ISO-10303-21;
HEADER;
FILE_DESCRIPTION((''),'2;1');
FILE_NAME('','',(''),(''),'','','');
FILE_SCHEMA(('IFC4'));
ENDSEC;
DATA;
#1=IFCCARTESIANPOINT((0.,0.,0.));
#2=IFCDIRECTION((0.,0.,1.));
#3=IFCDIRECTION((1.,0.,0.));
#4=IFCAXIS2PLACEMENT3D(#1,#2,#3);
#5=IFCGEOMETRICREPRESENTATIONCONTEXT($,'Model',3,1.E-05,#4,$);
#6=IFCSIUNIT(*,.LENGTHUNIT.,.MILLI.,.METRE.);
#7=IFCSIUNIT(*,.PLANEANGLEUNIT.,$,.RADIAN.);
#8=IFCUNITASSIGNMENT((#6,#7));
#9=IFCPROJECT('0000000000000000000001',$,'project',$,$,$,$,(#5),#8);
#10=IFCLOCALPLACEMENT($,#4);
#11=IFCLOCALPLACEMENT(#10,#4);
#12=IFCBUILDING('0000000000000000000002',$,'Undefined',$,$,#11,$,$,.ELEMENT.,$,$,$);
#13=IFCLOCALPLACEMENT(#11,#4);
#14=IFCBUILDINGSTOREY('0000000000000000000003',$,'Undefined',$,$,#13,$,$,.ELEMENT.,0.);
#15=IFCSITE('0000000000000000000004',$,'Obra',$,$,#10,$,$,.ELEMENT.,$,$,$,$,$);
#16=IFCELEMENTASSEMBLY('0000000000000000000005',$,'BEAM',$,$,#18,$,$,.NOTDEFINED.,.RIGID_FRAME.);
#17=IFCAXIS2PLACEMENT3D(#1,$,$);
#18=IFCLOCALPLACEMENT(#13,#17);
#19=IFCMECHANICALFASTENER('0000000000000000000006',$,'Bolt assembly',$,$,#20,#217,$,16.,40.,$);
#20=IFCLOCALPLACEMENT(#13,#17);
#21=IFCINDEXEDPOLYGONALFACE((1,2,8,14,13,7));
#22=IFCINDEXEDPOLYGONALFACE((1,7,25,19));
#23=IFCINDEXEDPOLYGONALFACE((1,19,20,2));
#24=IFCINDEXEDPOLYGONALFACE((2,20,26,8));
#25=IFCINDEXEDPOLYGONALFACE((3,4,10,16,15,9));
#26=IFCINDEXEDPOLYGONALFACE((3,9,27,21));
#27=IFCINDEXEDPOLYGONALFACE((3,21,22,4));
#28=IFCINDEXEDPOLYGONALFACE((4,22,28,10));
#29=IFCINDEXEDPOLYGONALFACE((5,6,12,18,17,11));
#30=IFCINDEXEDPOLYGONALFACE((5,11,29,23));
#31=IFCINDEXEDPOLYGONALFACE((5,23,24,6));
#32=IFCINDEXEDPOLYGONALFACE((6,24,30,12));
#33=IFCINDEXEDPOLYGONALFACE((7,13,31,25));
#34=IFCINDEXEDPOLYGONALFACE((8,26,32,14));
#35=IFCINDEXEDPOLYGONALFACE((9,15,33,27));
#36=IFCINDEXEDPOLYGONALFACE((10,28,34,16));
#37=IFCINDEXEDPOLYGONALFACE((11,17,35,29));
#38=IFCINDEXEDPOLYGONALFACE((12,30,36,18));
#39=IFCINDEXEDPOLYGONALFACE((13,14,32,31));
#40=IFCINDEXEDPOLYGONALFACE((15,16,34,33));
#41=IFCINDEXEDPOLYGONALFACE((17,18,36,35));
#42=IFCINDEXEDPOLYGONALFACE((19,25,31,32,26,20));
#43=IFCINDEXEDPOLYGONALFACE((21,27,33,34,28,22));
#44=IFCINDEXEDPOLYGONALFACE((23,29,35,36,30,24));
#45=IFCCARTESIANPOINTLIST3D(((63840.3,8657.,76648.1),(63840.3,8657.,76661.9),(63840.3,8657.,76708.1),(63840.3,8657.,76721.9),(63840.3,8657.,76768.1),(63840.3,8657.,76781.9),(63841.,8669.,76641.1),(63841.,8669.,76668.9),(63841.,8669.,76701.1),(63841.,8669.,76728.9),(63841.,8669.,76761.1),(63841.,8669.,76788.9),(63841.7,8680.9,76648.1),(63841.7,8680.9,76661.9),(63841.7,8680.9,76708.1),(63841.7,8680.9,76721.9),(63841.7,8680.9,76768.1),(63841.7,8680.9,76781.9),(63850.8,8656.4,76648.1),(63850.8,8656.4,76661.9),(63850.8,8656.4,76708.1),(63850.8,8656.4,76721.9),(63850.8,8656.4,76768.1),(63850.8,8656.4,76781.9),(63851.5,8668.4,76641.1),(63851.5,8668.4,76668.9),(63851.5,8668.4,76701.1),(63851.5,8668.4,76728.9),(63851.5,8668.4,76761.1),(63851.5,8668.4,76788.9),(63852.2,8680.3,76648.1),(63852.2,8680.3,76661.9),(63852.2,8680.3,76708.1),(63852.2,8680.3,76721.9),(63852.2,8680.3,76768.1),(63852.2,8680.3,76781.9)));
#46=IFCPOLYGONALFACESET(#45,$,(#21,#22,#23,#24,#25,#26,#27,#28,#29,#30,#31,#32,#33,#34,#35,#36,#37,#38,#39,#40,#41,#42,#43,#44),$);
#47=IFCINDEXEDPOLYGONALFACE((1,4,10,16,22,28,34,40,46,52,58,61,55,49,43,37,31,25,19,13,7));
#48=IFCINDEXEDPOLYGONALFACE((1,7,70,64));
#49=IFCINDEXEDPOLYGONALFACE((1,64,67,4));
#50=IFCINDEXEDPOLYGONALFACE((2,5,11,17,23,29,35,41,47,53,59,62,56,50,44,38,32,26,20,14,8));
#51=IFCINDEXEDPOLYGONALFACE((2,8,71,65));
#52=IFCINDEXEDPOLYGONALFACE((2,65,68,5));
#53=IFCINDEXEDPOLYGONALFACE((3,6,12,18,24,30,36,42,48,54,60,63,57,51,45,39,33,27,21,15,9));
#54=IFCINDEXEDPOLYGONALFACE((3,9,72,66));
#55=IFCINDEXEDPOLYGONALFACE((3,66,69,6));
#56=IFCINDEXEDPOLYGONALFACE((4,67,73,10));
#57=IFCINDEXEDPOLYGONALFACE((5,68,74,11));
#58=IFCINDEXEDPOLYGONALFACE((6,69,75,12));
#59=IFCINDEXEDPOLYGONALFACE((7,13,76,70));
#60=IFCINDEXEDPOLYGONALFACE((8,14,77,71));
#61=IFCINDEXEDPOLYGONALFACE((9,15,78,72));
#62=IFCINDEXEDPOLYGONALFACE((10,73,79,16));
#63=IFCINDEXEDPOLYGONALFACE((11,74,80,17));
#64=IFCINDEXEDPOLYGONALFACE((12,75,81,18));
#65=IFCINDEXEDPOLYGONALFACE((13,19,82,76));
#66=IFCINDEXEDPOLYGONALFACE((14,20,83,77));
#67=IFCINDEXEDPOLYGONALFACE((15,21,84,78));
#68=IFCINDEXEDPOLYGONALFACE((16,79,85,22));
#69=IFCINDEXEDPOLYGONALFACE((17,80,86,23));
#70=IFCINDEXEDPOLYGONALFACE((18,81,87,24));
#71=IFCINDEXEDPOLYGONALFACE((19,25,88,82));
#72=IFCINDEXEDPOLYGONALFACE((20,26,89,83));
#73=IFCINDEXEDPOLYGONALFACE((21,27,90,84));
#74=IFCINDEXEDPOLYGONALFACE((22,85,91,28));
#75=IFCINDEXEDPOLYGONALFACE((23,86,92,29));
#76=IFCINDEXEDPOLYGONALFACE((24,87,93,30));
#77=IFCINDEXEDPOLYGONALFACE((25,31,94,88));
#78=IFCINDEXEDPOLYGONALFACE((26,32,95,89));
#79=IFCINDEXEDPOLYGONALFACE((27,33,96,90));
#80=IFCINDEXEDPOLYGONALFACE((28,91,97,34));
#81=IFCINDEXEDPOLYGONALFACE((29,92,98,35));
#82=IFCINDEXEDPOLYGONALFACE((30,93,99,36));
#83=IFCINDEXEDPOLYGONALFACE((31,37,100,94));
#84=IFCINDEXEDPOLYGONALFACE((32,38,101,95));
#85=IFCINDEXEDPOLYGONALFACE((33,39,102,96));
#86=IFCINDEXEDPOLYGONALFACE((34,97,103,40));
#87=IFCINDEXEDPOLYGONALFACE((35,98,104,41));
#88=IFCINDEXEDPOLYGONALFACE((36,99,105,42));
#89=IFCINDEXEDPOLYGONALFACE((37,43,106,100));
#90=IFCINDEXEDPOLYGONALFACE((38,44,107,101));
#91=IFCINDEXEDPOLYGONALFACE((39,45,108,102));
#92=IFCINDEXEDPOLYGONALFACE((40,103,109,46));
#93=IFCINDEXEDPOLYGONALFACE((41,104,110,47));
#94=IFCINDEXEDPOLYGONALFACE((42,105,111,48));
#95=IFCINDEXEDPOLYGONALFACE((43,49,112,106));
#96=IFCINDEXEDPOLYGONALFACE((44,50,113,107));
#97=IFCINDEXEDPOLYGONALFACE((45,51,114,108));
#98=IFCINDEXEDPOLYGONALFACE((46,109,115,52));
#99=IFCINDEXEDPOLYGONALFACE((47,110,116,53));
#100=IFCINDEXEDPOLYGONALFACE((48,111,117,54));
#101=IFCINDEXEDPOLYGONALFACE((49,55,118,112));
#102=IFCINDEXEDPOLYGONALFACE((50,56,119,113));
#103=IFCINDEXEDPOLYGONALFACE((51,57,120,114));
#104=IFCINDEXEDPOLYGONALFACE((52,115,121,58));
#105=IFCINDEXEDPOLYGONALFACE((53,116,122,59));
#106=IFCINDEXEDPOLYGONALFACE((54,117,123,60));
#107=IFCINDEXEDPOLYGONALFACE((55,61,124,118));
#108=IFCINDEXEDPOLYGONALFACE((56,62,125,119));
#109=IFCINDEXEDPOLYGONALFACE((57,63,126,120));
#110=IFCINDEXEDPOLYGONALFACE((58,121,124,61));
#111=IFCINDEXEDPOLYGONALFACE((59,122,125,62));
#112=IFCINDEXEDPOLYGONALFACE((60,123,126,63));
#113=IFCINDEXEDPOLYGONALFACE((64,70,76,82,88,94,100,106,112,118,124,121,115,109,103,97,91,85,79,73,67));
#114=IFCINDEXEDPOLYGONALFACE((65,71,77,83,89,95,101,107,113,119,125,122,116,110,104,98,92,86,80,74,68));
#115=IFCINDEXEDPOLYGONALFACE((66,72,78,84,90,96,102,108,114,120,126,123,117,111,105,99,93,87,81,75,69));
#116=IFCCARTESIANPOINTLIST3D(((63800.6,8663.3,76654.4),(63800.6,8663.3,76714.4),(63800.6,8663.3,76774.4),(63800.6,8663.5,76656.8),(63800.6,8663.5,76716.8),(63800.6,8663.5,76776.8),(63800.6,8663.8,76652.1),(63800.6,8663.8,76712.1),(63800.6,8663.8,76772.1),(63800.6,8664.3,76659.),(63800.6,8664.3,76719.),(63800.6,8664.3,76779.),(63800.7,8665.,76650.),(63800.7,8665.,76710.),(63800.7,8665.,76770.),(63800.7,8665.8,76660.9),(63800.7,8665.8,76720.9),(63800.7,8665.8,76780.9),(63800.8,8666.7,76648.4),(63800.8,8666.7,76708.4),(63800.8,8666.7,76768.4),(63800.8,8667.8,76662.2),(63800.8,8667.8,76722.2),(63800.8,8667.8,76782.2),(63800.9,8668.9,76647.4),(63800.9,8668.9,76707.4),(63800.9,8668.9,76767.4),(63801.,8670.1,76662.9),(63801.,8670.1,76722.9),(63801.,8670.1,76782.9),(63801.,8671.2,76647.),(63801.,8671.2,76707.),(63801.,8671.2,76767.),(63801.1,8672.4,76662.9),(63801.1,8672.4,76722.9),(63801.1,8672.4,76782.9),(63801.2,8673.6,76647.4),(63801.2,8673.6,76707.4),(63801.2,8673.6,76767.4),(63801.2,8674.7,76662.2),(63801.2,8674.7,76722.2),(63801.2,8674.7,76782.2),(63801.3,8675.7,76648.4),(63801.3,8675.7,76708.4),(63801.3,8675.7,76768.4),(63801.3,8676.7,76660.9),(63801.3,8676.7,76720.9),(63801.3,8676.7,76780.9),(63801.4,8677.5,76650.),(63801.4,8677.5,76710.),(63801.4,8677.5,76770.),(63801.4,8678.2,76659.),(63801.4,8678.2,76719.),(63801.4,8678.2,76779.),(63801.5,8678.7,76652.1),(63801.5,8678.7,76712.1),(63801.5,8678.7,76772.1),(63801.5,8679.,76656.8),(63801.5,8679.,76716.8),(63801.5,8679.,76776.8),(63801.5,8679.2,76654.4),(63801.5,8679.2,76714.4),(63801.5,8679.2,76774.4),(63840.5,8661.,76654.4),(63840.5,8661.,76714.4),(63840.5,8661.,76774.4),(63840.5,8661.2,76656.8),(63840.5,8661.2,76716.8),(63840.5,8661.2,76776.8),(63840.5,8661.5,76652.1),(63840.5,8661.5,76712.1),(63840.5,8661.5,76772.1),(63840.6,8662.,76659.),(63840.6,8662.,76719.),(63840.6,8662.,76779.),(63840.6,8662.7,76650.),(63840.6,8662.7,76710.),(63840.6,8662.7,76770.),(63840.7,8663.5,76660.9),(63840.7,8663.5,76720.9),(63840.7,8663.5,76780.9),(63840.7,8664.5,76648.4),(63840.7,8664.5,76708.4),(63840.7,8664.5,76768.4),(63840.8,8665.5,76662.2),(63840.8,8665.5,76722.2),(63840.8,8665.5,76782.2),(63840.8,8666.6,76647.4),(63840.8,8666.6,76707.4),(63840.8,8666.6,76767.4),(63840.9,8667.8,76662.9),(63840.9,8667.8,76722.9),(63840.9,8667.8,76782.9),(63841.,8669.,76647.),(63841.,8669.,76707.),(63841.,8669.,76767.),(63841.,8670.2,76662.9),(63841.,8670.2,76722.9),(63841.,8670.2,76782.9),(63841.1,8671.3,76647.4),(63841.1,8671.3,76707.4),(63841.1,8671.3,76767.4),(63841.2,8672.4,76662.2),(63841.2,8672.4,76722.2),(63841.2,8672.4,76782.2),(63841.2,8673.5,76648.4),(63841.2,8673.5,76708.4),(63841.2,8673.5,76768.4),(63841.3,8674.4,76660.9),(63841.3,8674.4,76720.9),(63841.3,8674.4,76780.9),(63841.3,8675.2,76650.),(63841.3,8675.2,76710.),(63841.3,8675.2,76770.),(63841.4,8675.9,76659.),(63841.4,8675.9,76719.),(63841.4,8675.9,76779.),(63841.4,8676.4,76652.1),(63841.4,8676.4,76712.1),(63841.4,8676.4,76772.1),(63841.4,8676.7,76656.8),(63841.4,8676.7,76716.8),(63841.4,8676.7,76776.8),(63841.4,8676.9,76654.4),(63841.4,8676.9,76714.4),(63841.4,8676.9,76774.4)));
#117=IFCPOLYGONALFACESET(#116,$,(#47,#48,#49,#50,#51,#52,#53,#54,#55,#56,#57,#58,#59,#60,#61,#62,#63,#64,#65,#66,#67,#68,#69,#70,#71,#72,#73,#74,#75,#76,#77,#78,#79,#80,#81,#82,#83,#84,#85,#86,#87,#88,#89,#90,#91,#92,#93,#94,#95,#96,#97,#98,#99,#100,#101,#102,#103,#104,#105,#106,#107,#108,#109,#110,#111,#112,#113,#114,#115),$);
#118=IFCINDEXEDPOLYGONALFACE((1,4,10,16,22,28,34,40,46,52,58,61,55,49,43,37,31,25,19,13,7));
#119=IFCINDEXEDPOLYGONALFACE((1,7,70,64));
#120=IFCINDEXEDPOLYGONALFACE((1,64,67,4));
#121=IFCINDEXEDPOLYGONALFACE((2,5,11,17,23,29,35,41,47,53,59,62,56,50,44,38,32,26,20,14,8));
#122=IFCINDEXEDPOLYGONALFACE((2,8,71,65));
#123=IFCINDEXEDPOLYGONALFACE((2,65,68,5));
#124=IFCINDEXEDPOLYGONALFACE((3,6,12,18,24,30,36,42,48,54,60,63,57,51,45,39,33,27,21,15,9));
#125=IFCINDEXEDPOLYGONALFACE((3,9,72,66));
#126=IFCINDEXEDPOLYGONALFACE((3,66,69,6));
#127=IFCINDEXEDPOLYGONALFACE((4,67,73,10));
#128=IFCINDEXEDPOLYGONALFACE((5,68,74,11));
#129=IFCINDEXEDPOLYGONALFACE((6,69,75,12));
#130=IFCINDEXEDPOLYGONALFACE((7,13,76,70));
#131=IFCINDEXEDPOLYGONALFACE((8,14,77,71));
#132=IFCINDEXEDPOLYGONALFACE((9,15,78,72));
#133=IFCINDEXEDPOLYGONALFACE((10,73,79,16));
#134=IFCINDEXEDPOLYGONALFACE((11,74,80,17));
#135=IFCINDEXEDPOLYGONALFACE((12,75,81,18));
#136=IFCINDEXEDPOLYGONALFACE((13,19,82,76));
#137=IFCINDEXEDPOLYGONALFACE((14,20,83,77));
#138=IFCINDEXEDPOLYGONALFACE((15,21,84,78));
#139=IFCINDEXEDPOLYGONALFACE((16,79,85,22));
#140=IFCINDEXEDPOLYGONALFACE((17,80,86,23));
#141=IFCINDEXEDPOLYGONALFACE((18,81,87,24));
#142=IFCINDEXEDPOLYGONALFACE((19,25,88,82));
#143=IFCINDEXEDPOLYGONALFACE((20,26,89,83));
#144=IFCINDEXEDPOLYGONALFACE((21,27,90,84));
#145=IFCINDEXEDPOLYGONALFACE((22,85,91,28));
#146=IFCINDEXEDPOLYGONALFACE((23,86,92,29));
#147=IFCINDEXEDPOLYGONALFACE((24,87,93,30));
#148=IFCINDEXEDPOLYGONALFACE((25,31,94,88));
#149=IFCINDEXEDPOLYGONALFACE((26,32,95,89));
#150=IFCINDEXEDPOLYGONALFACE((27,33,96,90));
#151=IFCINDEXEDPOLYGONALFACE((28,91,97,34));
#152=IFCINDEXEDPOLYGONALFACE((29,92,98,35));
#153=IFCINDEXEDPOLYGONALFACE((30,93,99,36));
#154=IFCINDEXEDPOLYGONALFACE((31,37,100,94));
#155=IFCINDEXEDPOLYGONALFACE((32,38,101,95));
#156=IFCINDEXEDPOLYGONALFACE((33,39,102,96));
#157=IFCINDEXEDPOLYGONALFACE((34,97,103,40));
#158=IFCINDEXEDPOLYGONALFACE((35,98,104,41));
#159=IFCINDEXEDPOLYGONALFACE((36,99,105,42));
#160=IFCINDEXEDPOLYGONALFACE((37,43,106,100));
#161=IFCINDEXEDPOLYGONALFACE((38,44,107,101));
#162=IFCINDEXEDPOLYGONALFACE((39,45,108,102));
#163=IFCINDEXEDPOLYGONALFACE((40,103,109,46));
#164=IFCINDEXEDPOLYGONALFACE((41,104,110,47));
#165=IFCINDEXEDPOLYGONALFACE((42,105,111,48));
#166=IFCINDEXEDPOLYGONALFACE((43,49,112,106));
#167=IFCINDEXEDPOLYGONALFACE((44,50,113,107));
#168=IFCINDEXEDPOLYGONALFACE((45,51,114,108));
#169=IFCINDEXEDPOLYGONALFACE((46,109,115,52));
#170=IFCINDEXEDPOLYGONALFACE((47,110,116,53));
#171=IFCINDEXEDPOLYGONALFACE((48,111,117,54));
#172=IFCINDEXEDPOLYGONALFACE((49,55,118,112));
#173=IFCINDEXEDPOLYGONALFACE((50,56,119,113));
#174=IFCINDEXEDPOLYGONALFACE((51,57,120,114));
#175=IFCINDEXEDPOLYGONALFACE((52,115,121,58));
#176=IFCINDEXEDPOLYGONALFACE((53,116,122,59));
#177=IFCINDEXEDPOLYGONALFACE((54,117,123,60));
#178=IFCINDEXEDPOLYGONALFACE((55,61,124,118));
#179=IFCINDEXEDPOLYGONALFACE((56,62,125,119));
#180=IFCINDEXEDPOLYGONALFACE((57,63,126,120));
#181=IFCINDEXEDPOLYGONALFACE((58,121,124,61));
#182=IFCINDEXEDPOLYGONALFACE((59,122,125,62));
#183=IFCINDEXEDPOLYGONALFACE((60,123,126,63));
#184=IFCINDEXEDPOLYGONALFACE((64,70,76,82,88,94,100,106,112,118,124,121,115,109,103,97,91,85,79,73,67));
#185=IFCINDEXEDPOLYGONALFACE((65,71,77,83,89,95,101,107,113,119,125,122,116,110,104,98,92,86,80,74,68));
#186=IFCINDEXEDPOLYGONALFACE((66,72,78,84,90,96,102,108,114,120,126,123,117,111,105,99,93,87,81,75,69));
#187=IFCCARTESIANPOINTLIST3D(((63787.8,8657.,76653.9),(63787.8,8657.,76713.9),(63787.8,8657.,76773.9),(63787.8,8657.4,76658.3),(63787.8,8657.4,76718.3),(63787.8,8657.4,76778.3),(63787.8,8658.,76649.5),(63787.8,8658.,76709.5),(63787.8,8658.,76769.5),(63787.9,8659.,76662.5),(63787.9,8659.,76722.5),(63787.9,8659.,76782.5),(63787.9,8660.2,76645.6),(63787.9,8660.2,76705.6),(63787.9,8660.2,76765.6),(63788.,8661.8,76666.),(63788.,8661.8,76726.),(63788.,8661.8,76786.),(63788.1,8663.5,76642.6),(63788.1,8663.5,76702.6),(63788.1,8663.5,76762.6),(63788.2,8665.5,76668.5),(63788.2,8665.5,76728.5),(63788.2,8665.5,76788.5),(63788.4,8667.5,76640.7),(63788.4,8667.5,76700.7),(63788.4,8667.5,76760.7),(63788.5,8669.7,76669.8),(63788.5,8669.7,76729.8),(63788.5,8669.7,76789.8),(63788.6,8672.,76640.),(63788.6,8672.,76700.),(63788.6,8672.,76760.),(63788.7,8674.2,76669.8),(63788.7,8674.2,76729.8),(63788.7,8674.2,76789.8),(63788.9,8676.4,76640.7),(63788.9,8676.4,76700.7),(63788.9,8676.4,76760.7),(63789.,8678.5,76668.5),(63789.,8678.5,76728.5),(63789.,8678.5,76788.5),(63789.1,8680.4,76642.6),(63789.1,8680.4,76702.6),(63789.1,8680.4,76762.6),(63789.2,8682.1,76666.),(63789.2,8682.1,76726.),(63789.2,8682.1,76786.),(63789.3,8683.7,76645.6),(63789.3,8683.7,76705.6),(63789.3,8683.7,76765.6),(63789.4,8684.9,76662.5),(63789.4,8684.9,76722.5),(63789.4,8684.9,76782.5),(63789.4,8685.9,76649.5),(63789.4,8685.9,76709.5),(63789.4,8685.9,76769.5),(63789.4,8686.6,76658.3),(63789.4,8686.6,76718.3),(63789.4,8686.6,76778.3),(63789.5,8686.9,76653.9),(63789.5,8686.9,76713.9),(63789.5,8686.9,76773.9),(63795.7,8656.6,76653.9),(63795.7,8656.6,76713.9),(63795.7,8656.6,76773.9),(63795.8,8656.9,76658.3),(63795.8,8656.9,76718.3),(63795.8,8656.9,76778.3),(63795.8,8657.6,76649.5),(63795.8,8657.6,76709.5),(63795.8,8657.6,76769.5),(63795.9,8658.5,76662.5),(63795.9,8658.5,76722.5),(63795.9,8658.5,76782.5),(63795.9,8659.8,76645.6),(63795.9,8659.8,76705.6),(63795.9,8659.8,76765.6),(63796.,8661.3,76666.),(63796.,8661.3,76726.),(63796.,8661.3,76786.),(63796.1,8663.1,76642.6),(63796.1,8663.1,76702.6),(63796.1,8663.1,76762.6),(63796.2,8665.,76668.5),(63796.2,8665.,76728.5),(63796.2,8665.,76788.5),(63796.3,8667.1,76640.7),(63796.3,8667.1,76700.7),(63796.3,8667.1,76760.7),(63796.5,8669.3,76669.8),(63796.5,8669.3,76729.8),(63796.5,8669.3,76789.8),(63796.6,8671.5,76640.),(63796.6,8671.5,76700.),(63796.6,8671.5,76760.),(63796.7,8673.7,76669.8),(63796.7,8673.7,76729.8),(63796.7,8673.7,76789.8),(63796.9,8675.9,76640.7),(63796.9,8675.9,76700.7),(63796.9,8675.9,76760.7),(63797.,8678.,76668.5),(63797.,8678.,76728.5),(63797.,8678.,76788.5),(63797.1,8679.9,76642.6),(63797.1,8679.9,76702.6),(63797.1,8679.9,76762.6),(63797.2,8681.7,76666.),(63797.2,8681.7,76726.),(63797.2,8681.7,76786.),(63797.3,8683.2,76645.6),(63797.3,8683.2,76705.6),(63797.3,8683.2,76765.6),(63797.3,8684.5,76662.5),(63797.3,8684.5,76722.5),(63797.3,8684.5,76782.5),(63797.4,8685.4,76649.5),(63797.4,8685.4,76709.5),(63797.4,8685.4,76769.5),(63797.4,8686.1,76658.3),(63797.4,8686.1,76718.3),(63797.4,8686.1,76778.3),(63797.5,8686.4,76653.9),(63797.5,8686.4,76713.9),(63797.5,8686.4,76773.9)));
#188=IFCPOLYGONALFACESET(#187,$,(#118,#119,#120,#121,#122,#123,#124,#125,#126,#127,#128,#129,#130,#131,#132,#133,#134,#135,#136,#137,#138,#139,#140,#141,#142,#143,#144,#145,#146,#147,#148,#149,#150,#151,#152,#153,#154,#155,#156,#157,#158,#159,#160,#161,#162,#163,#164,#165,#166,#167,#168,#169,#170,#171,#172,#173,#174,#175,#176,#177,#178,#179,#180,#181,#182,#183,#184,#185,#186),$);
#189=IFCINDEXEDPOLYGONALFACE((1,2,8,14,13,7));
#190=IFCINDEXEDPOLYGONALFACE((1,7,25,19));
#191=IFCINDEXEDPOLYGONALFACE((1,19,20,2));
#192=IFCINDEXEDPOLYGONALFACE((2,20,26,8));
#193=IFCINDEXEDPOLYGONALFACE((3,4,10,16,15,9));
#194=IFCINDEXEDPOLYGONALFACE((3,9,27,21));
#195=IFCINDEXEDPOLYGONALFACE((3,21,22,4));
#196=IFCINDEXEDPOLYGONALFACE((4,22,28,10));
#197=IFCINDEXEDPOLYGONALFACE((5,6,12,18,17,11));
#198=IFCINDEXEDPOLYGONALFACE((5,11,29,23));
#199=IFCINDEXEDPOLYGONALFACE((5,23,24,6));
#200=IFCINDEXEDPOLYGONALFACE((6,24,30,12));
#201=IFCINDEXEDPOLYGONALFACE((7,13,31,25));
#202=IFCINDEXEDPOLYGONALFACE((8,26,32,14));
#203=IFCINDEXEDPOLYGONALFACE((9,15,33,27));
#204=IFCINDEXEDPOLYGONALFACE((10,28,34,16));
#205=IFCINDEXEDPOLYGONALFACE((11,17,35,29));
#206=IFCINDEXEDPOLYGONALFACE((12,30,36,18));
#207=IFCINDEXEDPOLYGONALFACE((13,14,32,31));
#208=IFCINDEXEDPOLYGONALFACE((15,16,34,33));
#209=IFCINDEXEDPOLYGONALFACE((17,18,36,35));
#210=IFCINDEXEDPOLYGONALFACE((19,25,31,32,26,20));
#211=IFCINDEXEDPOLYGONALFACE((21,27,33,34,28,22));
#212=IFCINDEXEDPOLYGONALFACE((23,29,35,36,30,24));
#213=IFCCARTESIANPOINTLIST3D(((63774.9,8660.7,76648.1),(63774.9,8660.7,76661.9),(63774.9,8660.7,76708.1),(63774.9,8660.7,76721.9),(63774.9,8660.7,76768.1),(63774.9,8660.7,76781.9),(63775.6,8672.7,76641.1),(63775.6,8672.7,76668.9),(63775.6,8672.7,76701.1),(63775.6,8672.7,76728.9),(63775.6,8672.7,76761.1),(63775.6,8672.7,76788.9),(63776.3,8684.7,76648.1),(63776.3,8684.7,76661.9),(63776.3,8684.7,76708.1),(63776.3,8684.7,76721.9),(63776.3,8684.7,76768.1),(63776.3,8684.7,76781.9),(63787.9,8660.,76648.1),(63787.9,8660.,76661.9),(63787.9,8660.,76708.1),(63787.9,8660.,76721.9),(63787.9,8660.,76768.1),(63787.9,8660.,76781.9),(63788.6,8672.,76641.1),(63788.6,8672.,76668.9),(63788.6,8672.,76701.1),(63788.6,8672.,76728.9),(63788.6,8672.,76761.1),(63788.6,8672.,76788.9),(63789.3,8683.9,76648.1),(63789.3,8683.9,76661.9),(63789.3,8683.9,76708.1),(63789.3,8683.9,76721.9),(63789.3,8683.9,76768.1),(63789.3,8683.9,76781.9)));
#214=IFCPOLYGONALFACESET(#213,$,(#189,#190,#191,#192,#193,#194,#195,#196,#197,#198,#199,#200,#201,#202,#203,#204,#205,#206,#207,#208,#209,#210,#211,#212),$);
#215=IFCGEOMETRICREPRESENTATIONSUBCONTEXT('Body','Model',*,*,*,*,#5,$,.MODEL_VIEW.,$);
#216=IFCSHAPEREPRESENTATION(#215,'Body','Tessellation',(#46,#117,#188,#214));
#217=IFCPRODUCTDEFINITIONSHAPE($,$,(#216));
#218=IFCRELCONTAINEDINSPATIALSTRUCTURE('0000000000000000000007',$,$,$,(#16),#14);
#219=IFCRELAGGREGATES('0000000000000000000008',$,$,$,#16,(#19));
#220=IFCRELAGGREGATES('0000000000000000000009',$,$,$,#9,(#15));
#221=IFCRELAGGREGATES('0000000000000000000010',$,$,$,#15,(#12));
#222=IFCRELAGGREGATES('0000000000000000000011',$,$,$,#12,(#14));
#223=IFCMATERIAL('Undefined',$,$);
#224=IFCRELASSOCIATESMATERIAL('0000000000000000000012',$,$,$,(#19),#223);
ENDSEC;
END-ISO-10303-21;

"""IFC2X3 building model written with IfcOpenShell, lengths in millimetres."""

from ifc_helpers import new_model, si_unit, frame, origin_with_axes, origin_2d_with_axis, place, context, subcontext, project, spatial, polyline, circle, outline, extrude, source, transform, mapped, material, element, aggregate, save


model = new_model("IFC2X3")

# Units and contexts
model_context = context("Model", 3, precision=1e-05, world=origin_with_axes())
body_context = subcontext(model_context, "Body", "Model", "MODEL_VIEW")
ifc_project = project(units=[si_unit("LENGTHUNIT", "METRE", prefix="MILLI"), si_unit("PLANEANGLEUNIT", "RADIAN")], contexts=[model_context])

# Site, building, storey
site_placement = place(None, origin_with_axes())
site = spatial("IfcSite", under=ifc_project, at=site_placement, Name="Obra", CompositionType="ELEMENT")
building_placement = place(site_placement, origin_with_axes())
building = spatial("IfcBuilding", under=site, at=building_placement, Name="Undefined", CompositionType="ELEMENT")
storey_placement = place(building_placement, origin_with_axes())
storey = spatial("IfcBuildingStorey", under=building, at=storey_placement, Name="Undefined", CompositionType="ELEMENT", Elevation=0.0)

# Element assembly
assembly_1_placement = place(storey_placement, origin_with_axes())
assembly_1 = element("IfcElementAssembly", 1, at=assembly_1_placement, inside=storey, Name="BEAM", AssemblyPlace="NOTDEFINED", PredefinedType="RIGID_FRAME")

# Mechanical fastener
ifc_material_1 = material(Name="Undefined")
shared_shape_1 = source(origin_with_axes(), body_context, "Body", "SweptSolid", [
    extrude(outline(polyline([(13.9, 0.0), (6.9, 12.0), (-6.9, 12.0), (-13.9, 0.0), (-6.9, -12.0), (6.9, -12.0), (13.9, 0.0)])), frame((0.0, -19.7, 0.0), z_axis=(0.0, 1.0, 0.0), x_axis=(1.0, 0.0, 0.0)), (0.0, 0.0, 1.0), 10.6),
    extrude(circle(Radius=8.0, at=origin_2d_with_axis()), frame((0.0, -9.1, 0.0), z_axis=(0.0, 1.0, 0.0), x_axis=(1.0, 0.0, 0.0)), (0.0, 0.0, 1.0), 40.0),
    extrude(circle(Radius=15.0, at=origin_2d_with_axis()), frame((0.0, 35.3, 0.0), z_axis=(0.0, 1.0, 0.0), x_axis=(1.0, 0.0, 0.0)), (0.0, 0.0, 1.0), 8.0),
    extrude(outline(polyline([(13.9, 0.0), (6.9, 12.0), (-6.9, 12.0), (-13.9, 0.0), (-6.9, -12.0), (6.9, -12.0), (13.9, 0.0)])), frame((0.0, 43.3, 0.0), z_axis=(0.0, 1.0, 0.0), x_axis=(1.0, 0.0, 0.0)), (0.0, 0.0, 1.0), 13.0),
])
mechanical_fastener_1_placement = place(assembly_1_placement, frame((63829.0, 8619.6, 76835.0), z_axis=(0.05711, 0.998368, 0.0), x_axis=(0.0, 0.0, -1.0)))
mechanical_fastener_1 = element("IfcMechanicalFastener", 2, at=mechanical_fastener_1_placement, material=ifc_material_1, Name="Bolt assembly", NominalDiameter=16.0, NominalLength=40.0, context=body_context, shape_type="MappedRepresentation", body=[
    mapped(shared_shape_1, transform((60.0, 0.0, 50.0))),
    mapped(shared_shape_1, transform((120.0, 0.0, 50.0))),
    mapped(shared_shape_1, transform((180.0, 0.0, 50.0))),
])
aggregate(assembly_1, [mechanical_fastener_1])

save(model, "model.ifc")
